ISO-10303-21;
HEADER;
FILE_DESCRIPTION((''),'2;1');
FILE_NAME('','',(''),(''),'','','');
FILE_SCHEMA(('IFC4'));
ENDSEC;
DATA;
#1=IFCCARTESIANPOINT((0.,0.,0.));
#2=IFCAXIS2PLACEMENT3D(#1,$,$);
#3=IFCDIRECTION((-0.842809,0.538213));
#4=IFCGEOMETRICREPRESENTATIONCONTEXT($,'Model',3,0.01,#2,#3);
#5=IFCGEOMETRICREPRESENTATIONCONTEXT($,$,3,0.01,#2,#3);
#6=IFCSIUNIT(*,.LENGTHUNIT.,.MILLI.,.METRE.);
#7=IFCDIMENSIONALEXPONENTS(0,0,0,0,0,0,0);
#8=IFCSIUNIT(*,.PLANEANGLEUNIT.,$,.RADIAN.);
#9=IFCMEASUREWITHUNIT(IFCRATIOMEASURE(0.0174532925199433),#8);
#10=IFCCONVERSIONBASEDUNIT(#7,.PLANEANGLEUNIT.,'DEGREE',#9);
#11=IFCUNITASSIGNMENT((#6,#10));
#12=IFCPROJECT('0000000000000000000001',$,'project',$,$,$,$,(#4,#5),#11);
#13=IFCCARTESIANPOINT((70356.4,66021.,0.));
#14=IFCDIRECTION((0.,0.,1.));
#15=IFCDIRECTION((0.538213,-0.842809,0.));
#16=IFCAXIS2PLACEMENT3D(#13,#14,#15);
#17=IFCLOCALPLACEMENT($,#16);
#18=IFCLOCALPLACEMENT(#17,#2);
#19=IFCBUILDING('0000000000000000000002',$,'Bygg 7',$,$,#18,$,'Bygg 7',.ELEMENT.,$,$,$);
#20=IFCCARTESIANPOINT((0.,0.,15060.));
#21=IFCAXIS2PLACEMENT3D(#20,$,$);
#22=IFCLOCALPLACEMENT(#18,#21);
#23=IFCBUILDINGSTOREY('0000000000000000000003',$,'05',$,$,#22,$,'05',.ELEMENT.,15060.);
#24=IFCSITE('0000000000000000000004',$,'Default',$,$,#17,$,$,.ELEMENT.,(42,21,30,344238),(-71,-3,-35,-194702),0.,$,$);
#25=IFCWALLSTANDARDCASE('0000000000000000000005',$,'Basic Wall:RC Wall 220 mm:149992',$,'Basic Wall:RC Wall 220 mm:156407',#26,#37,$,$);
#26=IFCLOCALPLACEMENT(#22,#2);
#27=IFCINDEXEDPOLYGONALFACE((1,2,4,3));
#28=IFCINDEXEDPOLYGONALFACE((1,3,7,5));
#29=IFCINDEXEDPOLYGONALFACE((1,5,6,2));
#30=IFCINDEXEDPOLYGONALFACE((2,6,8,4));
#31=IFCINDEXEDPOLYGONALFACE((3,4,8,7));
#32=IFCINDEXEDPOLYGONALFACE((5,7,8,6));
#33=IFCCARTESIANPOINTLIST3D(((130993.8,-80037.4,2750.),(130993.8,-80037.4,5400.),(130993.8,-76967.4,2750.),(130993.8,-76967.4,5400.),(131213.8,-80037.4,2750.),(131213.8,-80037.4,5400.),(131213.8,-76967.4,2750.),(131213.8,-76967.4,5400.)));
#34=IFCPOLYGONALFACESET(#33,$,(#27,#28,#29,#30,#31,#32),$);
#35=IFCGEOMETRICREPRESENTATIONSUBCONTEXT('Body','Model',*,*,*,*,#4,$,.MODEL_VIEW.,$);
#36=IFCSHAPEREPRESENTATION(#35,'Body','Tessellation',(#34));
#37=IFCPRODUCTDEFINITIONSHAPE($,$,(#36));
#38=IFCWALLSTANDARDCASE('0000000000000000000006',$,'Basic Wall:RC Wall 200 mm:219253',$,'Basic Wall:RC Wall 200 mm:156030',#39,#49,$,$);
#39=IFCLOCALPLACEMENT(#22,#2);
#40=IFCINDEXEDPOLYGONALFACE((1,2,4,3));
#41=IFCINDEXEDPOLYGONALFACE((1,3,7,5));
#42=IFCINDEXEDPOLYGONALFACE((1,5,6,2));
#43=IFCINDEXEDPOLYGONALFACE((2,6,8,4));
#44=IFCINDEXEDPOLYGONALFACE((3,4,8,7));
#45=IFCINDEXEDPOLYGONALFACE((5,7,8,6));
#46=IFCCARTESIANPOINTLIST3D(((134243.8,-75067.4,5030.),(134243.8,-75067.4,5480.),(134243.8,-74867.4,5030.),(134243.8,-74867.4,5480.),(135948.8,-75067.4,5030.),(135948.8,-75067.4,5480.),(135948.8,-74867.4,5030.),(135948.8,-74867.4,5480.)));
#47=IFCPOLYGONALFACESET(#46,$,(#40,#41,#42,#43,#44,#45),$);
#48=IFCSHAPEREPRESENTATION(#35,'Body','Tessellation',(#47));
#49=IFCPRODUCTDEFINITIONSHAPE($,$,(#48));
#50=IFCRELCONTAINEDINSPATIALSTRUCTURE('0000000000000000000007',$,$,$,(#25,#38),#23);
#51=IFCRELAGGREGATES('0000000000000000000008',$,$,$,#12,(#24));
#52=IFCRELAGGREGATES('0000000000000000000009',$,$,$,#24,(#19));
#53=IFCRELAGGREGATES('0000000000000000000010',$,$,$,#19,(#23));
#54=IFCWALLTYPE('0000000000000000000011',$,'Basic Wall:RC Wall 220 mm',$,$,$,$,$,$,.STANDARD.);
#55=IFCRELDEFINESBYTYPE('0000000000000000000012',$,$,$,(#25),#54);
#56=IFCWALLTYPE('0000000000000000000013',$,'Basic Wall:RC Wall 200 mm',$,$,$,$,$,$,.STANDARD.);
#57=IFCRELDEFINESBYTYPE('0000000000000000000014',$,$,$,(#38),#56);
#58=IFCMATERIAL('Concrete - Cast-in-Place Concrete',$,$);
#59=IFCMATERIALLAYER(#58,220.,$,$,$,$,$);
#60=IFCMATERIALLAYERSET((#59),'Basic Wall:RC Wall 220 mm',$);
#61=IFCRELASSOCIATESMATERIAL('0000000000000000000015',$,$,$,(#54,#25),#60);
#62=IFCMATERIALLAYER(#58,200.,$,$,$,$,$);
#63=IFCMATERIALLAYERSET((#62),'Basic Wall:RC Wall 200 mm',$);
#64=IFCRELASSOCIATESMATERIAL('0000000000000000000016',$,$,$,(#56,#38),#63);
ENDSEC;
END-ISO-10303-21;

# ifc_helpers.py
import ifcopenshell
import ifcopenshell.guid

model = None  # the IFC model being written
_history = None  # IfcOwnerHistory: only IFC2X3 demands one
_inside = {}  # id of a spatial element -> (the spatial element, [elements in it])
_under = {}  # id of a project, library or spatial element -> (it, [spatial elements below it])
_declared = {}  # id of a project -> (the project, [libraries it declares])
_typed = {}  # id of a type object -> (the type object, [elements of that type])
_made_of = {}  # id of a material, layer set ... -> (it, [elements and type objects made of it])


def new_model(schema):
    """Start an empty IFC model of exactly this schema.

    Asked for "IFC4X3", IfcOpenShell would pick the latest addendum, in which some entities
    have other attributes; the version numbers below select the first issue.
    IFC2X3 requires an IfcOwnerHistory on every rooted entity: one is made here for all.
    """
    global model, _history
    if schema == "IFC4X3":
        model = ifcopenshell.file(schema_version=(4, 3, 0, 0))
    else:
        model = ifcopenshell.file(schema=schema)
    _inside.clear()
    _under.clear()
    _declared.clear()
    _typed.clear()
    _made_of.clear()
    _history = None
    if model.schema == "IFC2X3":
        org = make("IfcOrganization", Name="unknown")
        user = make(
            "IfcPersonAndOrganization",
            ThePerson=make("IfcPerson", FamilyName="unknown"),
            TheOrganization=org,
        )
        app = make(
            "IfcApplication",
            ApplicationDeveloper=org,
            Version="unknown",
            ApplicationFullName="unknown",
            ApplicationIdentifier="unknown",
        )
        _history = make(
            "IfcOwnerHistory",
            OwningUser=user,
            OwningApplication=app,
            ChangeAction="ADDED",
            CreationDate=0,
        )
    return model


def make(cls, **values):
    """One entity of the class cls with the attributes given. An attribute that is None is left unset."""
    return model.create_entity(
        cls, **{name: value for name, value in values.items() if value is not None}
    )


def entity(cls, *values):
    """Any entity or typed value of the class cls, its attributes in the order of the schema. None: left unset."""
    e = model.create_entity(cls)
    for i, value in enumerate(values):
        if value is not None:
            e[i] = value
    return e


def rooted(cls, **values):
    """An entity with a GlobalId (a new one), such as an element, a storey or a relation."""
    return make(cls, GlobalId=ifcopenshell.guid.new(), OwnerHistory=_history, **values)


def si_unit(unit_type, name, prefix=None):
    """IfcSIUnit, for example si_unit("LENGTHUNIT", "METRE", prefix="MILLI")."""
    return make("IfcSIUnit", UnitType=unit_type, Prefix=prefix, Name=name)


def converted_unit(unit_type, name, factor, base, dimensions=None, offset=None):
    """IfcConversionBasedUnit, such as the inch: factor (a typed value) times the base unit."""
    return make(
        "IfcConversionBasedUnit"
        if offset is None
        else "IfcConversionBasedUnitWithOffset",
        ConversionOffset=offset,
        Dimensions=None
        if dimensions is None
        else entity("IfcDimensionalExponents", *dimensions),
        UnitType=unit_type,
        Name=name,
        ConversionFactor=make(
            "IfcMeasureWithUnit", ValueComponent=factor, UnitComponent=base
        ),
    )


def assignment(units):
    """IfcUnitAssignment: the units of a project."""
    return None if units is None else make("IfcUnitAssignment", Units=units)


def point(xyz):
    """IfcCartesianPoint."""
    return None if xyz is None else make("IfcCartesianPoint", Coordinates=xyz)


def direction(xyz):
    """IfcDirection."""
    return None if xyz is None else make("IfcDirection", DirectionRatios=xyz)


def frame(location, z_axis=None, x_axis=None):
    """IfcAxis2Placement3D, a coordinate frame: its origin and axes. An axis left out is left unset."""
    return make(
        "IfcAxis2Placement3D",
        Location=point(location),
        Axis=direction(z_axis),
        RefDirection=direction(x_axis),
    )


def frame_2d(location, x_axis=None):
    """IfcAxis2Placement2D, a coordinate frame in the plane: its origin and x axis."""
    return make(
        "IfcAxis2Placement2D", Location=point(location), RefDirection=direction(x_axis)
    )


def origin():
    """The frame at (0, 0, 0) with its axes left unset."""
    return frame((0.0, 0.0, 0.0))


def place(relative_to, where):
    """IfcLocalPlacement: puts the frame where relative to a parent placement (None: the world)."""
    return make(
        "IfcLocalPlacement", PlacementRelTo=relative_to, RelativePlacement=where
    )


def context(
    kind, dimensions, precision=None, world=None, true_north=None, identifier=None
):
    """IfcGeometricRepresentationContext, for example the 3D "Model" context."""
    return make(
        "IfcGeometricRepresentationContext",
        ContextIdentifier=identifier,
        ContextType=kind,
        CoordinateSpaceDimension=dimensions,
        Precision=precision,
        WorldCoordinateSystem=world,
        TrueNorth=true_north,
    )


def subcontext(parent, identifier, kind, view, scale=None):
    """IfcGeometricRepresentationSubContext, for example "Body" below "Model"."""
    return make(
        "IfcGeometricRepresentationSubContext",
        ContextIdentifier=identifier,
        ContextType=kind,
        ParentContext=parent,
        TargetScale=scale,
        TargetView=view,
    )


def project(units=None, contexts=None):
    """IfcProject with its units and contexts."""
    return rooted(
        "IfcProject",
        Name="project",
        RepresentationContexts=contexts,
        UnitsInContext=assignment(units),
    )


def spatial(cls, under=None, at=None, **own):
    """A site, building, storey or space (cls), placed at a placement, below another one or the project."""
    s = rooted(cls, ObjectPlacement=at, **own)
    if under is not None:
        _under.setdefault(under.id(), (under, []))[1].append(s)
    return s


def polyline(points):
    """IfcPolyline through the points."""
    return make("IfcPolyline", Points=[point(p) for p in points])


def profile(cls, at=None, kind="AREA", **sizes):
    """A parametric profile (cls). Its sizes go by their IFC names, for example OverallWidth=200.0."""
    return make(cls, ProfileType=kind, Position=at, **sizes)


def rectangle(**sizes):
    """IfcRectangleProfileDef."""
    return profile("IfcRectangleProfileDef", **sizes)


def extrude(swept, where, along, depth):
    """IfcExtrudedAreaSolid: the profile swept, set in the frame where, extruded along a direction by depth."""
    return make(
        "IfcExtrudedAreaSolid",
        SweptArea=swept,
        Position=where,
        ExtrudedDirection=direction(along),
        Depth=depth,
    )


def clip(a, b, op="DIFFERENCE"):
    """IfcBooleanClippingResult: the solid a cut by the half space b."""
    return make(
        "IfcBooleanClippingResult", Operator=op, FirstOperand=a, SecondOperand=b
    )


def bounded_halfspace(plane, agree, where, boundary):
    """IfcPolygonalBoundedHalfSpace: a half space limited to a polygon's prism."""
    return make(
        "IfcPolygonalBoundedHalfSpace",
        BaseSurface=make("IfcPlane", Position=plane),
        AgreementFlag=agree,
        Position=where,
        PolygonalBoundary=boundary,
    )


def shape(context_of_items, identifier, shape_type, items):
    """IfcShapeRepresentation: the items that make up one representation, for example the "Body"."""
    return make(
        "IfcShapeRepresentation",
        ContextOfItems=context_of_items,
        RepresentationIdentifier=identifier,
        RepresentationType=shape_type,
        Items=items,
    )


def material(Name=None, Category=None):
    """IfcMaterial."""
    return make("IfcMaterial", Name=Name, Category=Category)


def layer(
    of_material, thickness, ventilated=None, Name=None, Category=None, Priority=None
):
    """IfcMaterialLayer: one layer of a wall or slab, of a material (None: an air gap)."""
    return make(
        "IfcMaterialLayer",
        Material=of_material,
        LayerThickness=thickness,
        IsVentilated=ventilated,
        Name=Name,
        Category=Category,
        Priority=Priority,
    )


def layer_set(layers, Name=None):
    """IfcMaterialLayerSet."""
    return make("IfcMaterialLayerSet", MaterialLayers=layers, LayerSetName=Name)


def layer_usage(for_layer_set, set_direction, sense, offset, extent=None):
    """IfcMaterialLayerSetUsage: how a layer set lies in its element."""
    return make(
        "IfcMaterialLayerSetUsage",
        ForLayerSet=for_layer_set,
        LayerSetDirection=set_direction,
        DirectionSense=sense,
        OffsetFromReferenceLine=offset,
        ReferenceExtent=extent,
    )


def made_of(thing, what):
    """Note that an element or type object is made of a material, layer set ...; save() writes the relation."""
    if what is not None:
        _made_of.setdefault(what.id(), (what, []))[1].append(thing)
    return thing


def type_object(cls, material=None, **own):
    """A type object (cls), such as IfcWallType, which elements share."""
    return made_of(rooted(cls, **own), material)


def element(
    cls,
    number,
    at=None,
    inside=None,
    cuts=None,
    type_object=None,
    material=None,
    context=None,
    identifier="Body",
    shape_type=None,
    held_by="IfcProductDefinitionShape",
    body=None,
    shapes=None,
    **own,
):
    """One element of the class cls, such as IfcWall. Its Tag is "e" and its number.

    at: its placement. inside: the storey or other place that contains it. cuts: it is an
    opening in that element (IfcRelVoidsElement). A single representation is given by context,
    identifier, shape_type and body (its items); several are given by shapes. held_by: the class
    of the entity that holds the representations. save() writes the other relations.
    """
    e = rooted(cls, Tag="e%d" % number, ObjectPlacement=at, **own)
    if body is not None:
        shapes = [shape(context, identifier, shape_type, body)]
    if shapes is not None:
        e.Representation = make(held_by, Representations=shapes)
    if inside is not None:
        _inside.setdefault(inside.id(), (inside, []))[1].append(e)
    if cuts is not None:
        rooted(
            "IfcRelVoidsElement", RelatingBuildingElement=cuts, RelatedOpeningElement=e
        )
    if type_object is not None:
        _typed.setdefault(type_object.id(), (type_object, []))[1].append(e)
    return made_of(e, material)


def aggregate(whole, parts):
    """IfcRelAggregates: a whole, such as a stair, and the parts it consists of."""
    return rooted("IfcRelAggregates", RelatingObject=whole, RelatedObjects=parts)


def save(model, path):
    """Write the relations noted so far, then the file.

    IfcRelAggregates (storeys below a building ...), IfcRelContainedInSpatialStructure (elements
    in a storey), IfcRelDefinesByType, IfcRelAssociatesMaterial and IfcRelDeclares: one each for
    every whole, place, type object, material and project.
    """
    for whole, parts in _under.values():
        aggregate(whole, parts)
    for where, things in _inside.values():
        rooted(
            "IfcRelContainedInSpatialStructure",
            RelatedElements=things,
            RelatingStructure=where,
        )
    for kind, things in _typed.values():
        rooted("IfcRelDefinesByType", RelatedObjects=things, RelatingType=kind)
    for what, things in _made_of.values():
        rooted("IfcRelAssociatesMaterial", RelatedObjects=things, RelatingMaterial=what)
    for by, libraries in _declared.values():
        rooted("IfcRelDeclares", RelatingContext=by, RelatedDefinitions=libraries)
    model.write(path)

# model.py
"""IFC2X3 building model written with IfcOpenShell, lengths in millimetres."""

from ifc_helpers import new_model, entity, si_unit, converted_unit, direction, frame, frame_2d, origin, place, context, subcontext, project, spatial, polyline, rectangle, extrude, clip, bounded_halfspace, material, layer, layer_set, layer_usage, type_object, element, save


model = new_model("IFC2X3")

# Units and contexts
model_context = context("Model", 3, precision=0.01, world=origin(), true_north=direction((-0.842809, 0.538213)))
context_of_model = context(None, 3, precision=0.01, world=origin(), true_north=direction((-0.842809, 0.538213)))
body_context = subcontext(model_context, "Body", "Model", "MODEL_VIEW")
ifc_project = project(units=[si_unit("LENGTHUNIT", "METRE", prefix="MILLI"), converted_unit("PLANEANGLEUNIT", "DEGREE", entity("IfcRatioMeasure", 0.0174532925199433), si_unit("PLANEANGLEUNIT", "RADIAN"), dimensions=[0, 0, 0, 0, 0, 0, 0])], contexts=[model_context, context_of_model])

# Site, building, storey
site_placement = place(None, frame((70356.4, 66021.0, 0.0), z_axis=(0.0, 0.0, 1.0), x_axis=(0.538213, -0.842809, 0.0)))
site = spatial("IfcSite", under=ifc_project, at=site_placement, Name="Default", CompositionType="ELEMENT", RefLatitude=(42, 21, 30, 344238), RefLongitude=(-71, -3, -35, -194702), RefElevation=0.0)
building_placement = place(site_placement, origin())
building = spatial("IfcBuilding", under=site, at=building_placement, Name="Bygg 7", LongName="Bygg 7", CompositionType="ELEMENT")
storey_placement = place(building_placement, frame((0.0, 0.0, 15060.0)))
storey = spatial("IfcBuildingStorey", under=building, at=storey_placement, Name="05", LongName="05", CompositionType="ELEMENT", Elevation=15060.0)

# Shared definitions
ifc_material_1 = material(Name="Concrete - Cast-in-Place Concrete")

# Shared definitions
ifc_layer_1 = layer(ifc_material_1, 220.0)
ifc_layer_set_1 = layer_set([ifc_layer_1], Name="Basic Wall:RC Wall 220 mm")
wall_type_1 = type_object("IfcWallType", Name="Basic Wall:RC Wall 220 mm", PredefinedType="STANDARD", material=ifc_layer_set_1)

# Walls
ifc_layer_usage_1 = layer_usage(ifc_layer_set_1, "AXIS2", "NEGATIVE", 110.0)
wall_1_placement = place(storey_placement, frame((131103.8, -80037.4, 2750.0), z_axis=(0.0, 0.0, 1.0), x_axis=(0.0, 1.0, 0.0)))
element("IfcWallStandardCase", 1, at=wall_1_placement, inside=storey, type_object=wall_type_1, material=ifc_layer_usage_1, Name="Basic Wall:RC Wall 220 mm:149992", ObjectType="Basic Wall:RC Wall 220 mm:156407", context=body_context, shape_type="Clipping", body=[
    clip(clip(extrude(rectangle(XDim=3070.0, YDim=220.0, at=frame_2d((1535.0, 0.0), x_axis=(-1.0, 0.0))), origin(), (0.0, 0.0, 1.0), 2650.0), bounded_halfspace(frame((0.0, -110.0, 2650.0), z_axis=(0.0, 0.0, -1.0), x_axis=(-0.99571, -0.092529, 0.0)), True, frame((0.0, -110.0, 2650.0)), polyline([(0.0, 0.0), (3070.0, 0.0), (3070.0, 220.0), (220.0, 220.0), (0.0, 220.0), (0.0, 0.0)]))), bounded_halfspace(frame((3070.0, -110.0, 0.0), z_axis=(0.0, 0.0, 1.0), x_axis=(0.99571, 0.092529, 0.0)), True, frame((3070.0, -110.0, 0.0)), polyline([(0.0, 0.0), (0.0, 220.0), (-2850.0, 220.0), (-3070.0, 220.0), (-3070.0, 0.0), (0.0, 0.0)]))),
])
ifc_layer_2 = layer(ifc_material_1, 200.0)
ifc_layer_set_2 = layer_set([ifc_layer_2], Name="Basic Wall:RC Wall 200 mm")
ifc_layer_usage_2 = layer_usage(ifc_layer_set_2, "AXIS2", "NEGATIVE", 100.0)
wall_type_2 = type_object("IfcWallType", Name="Basic Wall:RC Wall 200 mm", PredefinedType="STANDARD", material=ifc_layer_set_2)
wall_2_placement = place(storey_placement, frame((134243.8, -74967.4, 5030.0)))
element("IfcWallStandardCase", 2, at=wall_2_placement, inside=storey, type_object=wall_type_2, material=ifc_layer_usage_2, Name="Basic Wall:RC Wall 200 mm:219253", ObjectType="Basic Wall:RC Wall 200 mm:156030", context=body_context, shape_type="Clipping", body=[
    clip(extrude(rectangle(XDim=1705.0, YDim=200.0, at=frame_2d((852.5, 0.0), x_axis=(-1.0, 0.0))), origin(), (0.0, 0.0, 1.0), 450.0), bounded_halfspace(frame((0.0, -100.0, 450.0), z_axis=(0.0, 0.0, -1.0), x_axis=(1.0, 0.0, 0.0)), True, frame((0.0, -100.0, 450.0)), polyline([(0.0, 0.0), (1705.0, 0.0), (1705.0, 200.0), (0.0, 200.0), (0.0, 0.0)]))),
])

save(model, "model.ifc")
